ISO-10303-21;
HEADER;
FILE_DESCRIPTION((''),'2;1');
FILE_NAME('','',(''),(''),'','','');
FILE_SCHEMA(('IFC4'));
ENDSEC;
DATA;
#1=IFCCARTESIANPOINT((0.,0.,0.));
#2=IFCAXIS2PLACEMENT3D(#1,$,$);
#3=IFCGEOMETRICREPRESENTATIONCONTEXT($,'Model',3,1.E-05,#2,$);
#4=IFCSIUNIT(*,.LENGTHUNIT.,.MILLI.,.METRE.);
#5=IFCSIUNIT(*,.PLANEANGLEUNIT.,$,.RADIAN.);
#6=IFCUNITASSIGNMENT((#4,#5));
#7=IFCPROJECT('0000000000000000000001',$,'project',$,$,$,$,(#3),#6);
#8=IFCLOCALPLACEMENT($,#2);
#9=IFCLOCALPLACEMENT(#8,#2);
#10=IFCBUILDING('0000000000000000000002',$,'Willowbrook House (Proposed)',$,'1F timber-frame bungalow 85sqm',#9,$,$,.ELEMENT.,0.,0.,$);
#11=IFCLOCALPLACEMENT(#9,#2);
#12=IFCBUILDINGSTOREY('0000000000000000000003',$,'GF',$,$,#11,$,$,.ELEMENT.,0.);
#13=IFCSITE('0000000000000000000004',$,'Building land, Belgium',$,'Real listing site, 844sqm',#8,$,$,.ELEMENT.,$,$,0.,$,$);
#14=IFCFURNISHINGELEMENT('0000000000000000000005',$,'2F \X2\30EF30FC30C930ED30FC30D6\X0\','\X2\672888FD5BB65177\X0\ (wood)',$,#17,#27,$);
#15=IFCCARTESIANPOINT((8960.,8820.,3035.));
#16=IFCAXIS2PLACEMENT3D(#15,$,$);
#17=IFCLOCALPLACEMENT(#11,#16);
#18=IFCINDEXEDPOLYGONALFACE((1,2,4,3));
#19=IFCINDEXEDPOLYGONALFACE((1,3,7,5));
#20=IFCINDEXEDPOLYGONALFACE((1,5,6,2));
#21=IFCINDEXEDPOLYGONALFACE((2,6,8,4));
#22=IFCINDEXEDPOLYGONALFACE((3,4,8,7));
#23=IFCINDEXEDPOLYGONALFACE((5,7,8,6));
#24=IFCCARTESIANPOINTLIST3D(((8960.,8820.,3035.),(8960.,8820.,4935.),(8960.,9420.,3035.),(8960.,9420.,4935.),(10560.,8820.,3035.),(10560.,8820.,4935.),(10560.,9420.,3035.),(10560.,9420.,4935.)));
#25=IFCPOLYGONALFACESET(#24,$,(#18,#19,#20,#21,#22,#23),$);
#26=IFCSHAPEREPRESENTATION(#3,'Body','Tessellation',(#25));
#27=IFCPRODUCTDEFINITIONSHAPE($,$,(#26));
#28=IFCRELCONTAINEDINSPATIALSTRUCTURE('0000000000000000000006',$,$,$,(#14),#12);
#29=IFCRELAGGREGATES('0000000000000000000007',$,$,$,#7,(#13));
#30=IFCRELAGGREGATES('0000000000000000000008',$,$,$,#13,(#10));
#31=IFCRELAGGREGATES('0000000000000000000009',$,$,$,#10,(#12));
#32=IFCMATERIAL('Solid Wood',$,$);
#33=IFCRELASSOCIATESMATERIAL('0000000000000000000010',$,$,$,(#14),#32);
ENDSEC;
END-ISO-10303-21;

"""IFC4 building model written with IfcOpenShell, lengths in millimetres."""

from ifc_helpers import new_model, si_unit, frame, frame_2d, origin, place, context, project, spatial, rectangle, extrude, material, element, save


model = new_model("IFC4")

# Units and contexts
model_context = context("Model", 3, precision=1e-05, world=origin())
ifc_project = project(units=[si_unit("LENGTHUNIT", "METRE", prefix="MILLI"), si_unit("PLANEANGLEUNIT", "RADIAN")], contexts=[model_context])

# Site, building, storey
site_placement = place(None, origin())
site = spatial("IfcSite", under=ifc_project, at=site_placement, Name="Building land, Belgium", ObjectType="Real listing site, 844sqm", CompositionType="ELEMENT", RefElevation=0.0)
building_placement = place(site_placement, origin())
building = spatial("IfcBuilding", under=site, at=building_placement, Name="Willowbrook House (Proposed)", ObjectType="1F timber-frame bungalow 85sqm", CompositionType="ELEMENT", ElevationOfRefHeight=0.0, ElevationOfTerrain=0.0)
storey_placement = place(building_placement, origin())
storey = spatial("IfcBuildingStorey", under=building, at=storey_placement, Name="GF", CompositionType="ELEMENT", Elevation=0.0)

# Shared definitions
ifc_material_1 = material(Name="Solid Wood")

# Furnishing element
furnishing_1_placement = place(storey_placement, frame((8960.0, 8820.0, 3035.0)))
element("IfcFurnishingElement", 1, at=furnishing_1_placement, inside=storey, material=ifc_material_1, Name="2F ワードローブ", Description="木製家具 (wood)", context=model_context, shape_type="SweptSolid", body=[
    extrude(rectangle(XDim=1600.0, YDim=600.0, at=frame_2d((800.0, 300.0))), frame((8960.0, 8820.0, 3035.0)), (0.0, 0.0, 1.0), 1900.0),
])

save(model, "model.ifc")
